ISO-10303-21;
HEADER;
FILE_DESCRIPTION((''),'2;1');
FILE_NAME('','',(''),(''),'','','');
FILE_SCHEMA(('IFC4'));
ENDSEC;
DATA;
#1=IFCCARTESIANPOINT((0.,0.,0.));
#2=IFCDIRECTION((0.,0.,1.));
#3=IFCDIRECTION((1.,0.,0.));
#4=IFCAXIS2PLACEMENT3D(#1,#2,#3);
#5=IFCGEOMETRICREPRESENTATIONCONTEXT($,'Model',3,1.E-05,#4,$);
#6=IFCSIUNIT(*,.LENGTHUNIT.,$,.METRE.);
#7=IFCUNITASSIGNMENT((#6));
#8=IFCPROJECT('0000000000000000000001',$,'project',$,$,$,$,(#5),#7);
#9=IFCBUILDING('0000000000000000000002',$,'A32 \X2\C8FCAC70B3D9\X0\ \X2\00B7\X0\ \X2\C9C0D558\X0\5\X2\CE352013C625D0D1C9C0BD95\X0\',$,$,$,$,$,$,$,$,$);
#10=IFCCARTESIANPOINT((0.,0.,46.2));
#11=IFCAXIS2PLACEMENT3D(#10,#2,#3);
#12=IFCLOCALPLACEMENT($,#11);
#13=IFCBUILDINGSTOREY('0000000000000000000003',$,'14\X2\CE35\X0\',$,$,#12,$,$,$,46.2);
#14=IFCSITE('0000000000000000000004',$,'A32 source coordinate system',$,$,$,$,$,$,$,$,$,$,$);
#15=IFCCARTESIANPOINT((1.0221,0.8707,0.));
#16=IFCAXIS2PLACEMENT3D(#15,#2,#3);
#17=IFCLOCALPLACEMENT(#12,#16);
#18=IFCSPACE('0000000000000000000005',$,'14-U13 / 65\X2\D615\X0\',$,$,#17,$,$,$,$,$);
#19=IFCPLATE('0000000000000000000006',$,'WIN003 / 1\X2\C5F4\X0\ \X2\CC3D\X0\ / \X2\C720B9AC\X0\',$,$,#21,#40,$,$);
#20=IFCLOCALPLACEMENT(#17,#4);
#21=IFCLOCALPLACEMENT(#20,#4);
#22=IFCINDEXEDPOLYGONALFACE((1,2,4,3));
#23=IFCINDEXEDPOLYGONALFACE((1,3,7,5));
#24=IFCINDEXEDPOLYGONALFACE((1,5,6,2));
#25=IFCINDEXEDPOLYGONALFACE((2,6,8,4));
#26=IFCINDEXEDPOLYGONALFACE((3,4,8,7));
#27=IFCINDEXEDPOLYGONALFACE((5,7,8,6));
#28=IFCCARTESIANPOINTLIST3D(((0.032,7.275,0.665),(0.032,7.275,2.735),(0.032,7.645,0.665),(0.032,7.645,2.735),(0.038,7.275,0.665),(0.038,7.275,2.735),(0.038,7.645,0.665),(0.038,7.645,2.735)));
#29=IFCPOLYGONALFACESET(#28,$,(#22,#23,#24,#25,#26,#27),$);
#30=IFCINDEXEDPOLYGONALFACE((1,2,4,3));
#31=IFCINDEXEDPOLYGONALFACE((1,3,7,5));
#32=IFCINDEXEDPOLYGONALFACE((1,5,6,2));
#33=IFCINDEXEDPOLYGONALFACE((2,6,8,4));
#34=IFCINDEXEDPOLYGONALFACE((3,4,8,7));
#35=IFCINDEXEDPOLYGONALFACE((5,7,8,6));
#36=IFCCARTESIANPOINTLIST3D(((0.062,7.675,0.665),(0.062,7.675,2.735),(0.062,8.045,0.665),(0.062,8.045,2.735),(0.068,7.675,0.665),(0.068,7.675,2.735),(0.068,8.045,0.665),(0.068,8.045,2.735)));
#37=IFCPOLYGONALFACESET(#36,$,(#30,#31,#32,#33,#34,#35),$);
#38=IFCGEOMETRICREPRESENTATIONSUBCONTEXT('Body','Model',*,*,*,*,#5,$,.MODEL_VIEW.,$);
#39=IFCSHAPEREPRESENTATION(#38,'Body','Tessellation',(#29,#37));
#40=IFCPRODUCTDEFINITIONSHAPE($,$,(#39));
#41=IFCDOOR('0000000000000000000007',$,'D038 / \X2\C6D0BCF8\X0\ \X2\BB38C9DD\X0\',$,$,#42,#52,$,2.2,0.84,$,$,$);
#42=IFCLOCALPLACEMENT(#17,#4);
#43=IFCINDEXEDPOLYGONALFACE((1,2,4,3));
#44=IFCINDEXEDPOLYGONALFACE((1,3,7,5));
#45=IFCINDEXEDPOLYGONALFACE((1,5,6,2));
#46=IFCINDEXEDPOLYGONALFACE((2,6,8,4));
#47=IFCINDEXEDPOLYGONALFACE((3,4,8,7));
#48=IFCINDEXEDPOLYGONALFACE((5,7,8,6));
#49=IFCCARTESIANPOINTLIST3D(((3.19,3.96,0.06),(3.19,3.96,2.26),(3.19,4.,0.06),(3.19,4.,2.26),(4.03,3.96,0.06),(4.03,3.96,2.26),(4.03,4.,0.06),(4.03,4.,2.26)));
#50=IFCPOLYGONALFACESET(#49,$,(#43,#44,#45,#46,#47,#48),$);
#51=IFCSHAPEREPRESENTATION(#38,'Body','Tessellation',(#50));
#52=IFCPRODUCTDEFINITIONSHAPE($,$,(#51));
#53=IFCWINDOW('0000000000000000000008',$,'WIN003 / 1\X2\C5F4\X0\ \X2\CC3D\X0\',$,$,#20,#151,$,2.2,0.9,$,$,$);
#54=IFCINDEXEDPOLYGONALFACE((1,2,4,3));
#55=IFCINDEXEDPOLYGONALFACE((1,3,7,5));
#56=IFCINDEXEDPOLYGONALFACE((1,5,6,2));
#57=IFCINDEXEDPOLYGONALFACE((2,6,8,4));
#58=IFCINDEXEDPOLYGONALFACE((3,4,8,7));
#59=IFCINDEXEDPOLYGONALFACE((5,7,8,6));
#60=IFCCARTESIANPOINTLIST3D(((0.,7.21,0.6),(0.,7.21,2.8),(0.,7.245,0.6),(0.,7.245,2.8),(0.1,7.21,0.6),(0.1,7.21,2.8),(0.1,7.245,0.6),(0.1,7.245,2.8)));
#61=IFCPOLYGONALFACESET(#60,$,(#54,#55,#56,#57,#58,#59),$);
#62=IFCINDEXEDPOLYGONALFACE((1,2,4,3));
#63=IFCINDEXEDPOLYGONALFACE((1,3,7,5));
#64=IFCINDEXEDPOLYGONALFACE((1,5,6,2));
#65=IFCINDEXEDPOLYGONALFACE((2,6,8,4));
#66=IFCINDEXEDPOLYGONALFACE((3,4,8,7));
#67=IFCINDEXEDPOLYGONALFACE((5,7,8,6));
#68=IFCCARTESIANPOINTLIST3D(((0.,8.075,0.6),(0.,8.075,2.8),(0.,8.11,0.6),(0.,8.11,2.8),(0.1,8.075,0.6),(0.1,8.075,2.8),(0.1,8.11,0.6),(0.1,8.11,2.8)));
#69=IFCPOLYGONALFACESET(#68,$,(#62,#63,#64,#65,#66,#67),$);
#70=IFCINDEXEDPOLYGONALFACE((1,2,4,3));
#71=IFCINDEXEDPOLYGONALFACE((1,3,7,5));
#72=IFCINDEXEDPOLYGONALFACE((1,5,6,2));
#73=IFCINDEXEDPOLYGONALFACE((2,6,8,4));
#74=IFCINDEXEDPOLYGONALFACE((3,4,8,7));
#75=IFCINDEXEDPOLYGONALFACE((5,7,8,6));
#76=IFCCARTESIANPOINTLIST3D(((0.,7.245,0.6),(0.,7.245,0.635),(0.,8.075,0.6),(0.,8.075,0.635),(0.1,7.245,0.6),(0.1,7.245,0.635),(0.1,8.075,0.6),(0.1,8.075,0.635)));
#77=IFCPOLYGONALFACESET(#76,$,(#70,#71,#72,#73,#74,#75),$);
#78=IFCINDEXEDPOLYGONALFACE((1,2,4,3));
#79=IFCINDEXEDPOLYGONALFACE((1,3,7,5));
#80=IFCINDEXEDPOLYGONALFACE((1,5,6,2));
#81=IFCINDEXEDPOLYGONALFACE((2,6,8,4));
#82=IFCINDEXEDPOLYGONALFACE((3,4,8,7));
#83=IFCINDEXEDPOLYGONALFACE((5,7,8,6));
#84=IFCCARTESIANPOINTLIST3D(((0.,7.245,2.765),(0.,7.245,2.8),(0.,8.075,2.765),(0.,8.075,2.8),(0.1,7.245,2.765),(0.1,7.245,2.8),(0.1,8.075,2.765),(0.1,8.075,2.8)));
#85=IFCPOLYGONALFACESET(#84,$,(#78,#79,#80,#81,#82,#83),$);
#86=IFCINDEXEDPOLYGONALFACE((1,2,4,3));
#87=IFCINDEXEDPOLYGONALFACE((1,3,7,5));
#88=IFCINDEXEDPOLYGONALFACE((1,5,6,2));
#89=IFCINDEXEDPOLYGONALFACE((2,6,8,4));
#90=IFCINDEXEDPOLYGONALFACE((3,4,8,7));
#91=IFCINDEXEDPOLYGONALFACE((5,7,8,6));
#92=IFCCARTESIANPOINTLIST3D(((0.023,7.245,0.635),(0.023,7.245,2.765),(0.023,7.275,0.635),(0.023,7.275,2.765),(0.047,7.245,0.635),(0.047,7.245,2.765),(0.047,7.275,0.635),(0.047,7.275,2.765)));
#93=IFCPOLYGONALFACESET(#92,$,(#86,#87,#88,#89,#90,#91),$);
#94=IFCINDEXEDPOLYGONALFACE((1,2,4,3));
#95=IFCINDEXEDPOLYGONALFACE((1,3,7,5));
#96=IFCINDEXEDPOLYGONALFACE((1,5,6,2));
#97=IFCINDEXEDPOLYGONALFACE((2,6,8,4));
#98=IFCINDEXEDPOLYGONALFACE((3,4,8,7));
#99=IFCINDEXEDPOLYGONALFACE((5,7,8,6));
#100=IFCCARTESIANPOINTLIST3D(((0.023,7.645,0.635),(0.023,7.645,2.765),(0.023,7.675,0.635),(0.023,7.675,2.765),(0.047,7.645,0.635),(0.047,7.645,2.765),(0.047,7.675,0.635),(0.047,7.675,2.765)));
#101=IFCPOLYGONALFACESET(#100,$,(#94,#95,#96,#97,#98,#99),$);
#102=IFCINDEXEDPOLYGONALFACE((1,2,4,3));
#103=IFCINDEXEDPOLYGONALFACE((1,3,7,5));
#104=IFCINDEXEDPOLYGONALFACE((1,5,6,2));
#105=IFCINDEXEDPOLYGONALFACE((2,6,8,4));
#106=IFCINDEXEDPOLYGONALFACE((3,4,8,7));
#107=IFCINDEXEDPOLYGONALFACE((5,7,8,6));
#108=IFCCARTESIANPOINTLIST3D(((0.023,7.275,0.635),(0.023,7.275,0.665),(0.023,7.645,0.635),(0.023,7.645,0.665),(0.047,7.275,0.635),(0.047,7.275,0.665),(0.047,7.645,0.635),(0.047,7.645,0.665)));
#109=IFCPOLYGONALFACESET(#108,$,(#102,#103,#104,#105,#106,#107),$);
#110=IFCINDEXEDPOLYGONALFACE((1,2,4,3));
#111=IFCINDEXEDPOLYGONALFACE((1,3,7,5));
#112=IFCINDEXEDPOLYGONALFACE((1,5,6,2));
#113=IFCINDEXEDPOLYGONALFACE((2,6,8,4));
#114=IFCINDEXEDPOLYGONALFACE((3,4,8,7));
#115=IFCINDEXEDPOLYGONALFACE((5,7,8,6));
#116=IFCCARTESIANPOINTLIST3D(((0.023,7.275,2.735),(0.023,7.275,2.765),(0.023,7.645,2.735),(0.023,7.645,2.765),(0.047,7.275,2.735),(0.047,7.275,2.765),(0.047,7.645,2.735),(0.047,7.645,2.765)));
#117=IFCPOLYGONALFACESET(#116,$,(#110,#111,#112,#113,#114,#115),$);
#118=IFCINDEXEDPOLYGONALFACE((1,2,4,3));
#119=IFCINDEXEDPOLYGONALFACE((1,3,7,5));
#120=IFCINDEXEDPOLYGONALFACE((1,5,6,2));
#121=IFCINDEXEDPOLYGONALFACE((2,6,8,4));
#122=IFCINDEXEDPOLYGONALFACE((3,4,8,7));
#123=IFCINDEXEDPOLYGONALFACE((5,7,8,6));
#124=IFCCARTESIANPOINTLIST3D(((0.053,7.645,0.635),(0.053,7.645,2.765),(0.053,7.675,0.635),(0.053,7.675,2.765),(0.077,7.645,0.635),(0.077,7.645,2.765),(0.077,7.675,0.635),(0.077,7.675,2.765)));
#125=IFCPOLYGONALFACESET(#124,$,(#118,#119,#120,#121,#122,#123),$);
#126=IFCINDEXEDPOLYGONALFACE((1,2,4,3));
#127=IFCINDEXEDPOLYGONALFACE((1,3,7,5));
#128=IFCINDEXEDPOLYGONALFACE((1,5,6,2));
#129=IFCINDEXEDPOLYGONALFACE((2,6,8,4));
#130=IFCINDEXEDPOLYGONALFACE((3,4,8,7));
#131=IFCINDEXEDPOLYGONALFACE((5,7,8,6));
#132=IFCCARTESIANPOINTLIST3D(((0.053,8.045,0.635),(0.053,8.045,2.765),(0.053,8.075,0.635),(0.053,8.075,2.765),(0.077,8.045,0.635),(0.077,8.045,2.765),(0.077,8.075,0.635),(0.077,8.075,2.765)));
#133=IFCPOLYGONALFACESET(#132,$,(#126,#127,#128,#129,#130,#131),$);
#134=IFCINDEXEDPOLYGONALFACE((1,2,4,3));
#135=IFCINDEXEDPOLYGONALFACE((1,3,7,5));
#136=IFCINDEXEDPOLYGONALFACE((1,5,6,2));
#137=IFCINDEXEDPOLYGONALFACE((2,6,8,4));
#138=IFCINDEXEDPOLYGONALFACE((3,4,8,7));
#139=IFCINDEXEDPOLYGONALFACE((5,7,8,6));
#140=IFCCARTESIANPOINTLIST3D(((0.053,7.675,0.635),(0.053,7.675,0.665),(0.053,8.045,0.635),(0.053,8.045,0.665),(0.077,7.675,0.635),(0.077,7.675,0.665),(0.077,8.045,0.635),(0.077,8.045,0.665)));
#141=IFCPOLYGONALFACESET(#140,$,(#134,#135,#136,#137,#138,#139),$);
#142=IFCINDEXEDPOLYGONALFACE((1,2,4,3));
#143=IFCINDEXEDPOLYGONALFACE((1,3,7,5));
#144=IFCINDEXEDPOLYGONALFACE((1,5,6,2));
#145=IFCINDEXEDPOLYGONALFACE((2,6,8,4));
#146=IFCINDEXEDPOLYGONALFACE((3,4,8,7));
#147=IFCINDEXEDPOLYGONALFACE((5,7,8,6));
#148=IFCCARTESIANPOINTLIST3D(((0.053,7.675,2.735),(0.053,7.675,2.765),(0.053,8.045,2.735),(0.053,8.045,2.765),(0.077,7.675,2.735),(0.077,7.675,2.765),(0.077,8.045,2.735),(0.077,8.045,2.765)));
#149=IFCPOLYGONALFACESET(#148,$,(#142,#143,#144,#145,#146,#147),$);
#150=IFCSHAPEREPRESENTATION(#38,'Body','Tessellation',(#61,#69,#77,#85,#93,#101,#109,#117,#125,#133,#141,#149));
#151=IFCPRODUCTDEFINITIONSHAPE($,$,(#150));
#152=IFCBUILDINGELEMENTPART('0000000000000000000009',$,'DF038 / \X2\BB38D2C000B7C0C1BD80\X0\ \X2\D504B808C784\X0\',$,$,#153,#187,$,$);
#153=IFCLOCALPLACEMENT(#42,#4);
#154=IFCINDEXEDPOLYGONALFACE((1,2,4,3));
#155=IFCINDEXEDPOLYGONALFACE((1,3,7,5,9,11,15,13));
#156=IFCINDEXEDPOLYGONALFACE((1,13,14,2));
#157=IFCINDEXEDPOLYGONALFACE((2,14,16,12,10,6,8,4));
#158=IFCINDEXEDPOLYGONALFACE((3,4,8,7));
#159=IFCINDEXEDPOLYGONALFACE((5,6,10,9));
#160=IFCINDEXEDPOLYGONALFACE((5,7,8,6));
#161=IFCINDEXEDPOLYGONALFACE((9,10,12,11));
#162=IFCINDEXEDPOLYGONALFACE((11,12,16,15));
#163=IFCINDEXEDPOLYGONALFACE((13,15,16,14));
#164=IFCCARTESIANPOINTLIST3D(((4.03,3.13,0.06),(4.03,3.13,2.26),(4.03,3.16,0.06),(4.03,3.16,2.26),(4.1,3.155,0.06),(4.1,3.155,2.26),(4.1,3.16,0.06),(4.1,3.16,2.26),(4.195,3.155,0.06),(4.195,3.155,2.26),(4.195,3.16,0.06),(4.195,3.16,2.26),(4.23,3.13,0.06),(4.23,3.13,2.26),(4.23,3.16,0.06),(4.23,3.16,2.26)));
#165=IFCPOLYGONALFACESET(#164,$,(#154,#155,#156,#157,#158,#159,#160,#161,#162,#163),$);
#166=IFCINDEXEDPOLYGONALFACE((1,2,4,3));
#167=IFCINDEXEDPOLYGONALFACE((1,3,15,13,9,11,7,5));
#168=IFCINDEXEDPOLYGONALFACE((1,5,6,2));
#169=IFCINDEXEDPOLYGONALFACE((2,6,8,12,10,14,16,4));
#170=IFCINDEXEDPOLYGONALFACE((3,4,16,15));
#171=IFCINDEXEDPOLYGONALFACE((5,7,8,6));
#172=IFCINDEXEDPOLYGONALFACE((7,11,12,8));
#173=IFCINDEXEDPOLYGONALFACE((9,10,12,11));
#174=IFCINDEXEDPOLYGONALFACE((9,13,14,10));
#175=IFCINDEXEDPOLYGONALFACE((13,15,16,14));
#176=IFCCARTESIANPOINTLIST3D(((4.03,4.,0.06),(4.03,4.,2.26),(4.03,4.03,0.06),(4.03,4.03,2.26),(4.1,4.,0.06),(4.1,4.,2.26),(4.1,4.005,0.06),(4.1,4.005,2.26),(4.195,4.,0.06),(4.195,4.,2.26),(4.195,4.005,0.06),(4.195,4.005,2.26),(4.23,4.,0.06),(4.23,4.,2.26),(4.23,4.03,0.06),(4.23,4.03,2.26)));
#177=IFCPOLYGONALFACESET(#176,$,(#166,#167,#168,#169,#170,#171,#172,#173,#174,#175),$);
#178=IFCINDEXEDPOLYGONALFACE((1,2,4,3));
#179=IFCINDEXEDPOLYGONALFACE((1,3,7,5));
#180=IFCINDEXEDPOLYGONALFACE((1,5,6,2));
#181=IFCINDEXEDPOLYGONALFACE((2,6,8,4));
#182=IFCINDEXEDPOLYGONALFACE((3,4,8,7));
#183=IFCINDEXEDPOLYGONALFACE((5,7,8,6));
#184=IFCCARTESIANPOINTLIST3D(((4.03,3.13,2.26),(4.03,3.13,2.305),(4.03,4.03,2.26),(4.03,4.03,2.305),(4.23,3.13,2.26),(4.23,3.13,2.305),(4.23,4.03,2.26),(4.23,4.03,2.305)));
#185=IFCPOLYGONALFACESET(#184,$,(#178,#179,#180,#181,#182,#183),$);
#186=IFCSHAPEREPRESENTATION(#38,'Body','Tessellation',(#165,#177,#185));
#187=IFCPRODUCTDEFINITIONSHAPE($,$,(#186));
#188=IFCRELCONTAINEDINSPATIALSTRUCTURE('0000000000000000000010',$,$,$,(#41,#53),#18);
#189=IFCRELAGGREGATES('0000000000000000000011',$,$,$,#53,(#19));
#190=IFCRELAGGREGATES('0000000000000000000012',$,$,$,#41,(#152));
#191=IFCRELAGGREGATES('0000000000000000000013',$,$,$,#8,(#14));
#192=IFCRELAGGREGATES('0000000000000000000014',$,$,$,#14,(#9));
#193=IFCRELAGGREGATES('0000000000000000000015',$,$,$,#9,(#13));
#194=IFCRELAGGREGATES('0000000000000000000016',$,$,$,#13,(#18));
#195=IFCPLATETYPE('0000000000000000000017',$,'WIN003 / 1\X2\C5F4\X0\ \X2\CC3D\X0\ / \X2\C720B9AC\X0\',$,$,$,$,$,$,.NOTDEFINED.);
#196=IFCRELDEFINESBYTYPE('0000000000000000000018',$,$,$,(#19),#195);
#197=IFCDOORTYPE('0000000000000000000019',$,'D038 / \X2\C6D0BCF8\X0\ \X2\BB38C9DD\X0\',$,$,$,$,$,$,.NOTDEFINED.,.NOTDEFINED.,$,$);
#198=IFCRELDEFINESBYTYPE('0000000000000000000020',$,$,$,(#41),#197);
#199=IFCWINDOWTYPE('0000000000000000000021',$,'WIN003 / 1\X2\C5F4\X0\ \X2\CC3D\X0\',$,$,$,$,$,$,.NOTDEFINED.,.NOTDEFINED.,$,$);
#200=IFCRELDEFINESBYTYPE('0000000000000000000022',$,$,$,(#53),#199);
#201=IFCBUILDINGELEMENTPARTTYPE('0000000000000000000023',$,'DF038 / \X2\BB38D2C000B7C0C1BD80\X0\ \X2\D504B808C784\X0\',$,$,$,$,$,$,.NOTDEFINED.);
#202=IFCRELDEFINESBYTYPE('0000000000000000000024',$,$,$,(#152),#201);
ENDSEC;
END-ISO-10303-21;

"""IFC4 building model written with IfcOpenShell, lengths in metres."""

from ifc_helpers import new_model, si_unit, frame, origin, origin_with_axes, place, context, subcontext, project, spatial, polyline, outline, extrude, source, transform, mapped, type_object, type_shapes, element, aggregate, save


model = new_model("IFC4")

# Units and contexts
model_context = context("Model", 3, precision=1e-05, world=origin_with_axes())
body_context = subcontext(model_context, "Body", "Model", "MODEL_VIEW")
ifc_project = project(units=[si_unit("LENGTHUNIT", "METRE")], contexts=[model_context])

# Plate
storey_placement = place(None, frame((0.0, 0.0, 46.2), z_axis=(0.0, 0.0, 1.0), x_axis=(1.0, 0.0, 0.0)))
space_placement = place(storey_placement, frame((1.0221, 0.8707, 0.0), z_axis=(0.0, 0.0, 1.0), x_axis=(1.0, 0.0, 0.0)))
plate_type_1 = type_object("IfcPlateType", Name="WIN003 / 1열 창 / 유리", PredefinedType="NOTDEFINED")
shared_shape_1 = source(origin(), body_context, "Body", "SweptSolid", [
    extrude(outline(polyline([(0.032, 7.275), (0.032, 7.645), (0.038, 7.645), (0.038, 7.275), (0.032, 7.275)])), frame((0.0, 0.0, 0.665)), (0.0, 0.0, 1.0), 2.07),
    extrude(outline(polyline([(0.062, 7.675), (0.062, 8.045), (0.068, 8.045), (0.068, 7.675), (0.062, 7.675)])), frame((0.0, 0.0, 0.665)), (0.0, 0.0, 1.0), 2.07),
])
type_shapes(plate_type_1, [shared_shape_1])
window_1_placement = place(space_placement, origin_with_axes())
plate_1_placement = place(window_1_placement, origin_with_axes())
plate_1 = element("IfcPlate", 1, at=plate_1_placement, type_object=plate_type_1, Name="WIN003 / 1열 창 / 유리", context=body_context, shape_type="MappedRepresentation", body=[
    mapped(shared_shape_1, transform((0.0, 0.0, 0.0), scale=1.0)),
])

# Site, building, storey, space
site = spatial("IfcSite", under=ifc_project, Name="A32 source coordinate system")
building = spatial("IfcBuilding", under=site, Name="A32 주거동 · 지하5층–옥탑지붕")
storey = spatial("IfcBuildingStorey", under=building, at=storey_placement, Name="14층", Elevation=46.2)
space = spatial("IfcSpace", under=storey, at=space_placement, Name="14-U13 / 65형")

# Door
door_type_1 = type_object("IfcDoorType", Name="D038 / 원본 문짝", OperationType="NOTDEFINED", PredefinedType="NOTDEFINED")
shared_shape_2 = source(origin(), body_context, "Body", "SweptSolid", [
    extrude(outline(polyline([(3.19, 3.96), (3.19, 4.0), (4.03, 4.0), (4.03, 3.96), (3.19, 3.96)])), frame((0.0, 0.0, 0.06)), (0.0, 0.0, 1.0), 2.2),
])
type_shapes(door_type_1, [shared_shape_2])
door_1_placement = place(space_placement, origin_with_axes())
door_1 = element("IfcDoor", 2, at=door_1_placement, inside=space, type_object=door_type_1, Name="D038 / 원본 문짝", OverallHeight=2.2, OverallWidth=0.84, context=body_context, shape_type="MappedRepresentation", body=[
    mapped(shared_shape_2, transform((0.0, 0.0, 0.0), scale=1.0)),
])

# Window
window_type_1 = type_object("IfcWindowType", Name="WIN003 / 1열 창", PartitioningType="NOTDEFINED", PredefinedType="NOTDEFINED")
shared_shape_3 = source(origin(), body_context, "Body", "SweptSolid", [
    extrude(outline(polyline([(0.0, 7.21), (0.0, 7.245), (0.1, 7.245), (0.1, 7.21), (0.0, 7.21)])), frame((0.0, 0.0, 0.6)), (0.0, 0.0, 1.0), 2.2),
    extrude(outline(polyline([(0.0, 8.075), (0.0, 8.11), (0.1, 8.11), (0.1, 8.075), (0.0, 8.075)])), frame((0.0, 0.0, 0.6)), (0.0, 0.0, 1.0), 2.2),
    extrude(outline(polyline([(0.0, 7.245), (0.0, 8.075), (0.1, 8.075), (0.1, 7.245), (0.0, 7.245)])), frame((0.0, 0.0, 0.6)), (0.0, 0.0, 1.0), 0.035),
    extrude(outline(polyline([(0.0, 7.245), (0.0, 8.075), (0.1, 8.075), (0.1, 7.245), (0.0, 7.245)])), frame((0.0, 0.0, 2.765)), (0.0, 0.0, 1.0), 0.035),
    extrude(outline(polyline([(0.023, 7.245), (0.023, 7.275), (0.047, 7.275), (0.047, 7.245), (0.023, 7.245)])), frame((0.0, 0.0, 0.635)), (0.0, 0.0, 1.0), 2.13),
    extrude(outline(polyline([(0.023, 7.645), (0.023, 7.675), (0.047, 7.675), (0.047, 7.645), (0.023, 7.645)])), frame((0.0, 0.0, 0.635)), (0.0, 0.0, 1.0), 2.13),
    extrude(outline(polyline([(0.023, 7.275), (0.023, 7.645), (0.047, 7.645), (0.047, 7.275), (0.023, 7.275)])), frame((0.0, 0.0, 0.635)), (0.0, 0.0, 1.0), 0.03),
    extrude(outline(polyline([(0.023, 7.275), (0.023, 7.645), (0.047, 7.645), (0.047, 7.275), (0.023, 7.275)])), frame((0.0, 0.0, 2.735)), (0.0, 0.0, 1.0), 0.03),
    extrude(outline(polyline([(0.053, 7.645), (0.053, 7.675), (0.077, 7.675), (0.077, 7.645), (0.053, 7.645)])), frame((0.0, 0.0, 0.635)), (0.0, 0.0, 1.0), 2.13),
    extrude(outline(polyline([(0.053, 8.045), (0.053, 8.075), (0.077, 8.075), (0.077, 8.045), (0.053, 8.045)])), frame((0.0, 0.0, 0.635)), (0.0, 0.0, 1.0), 2.13),
    extrude(outline(polyline([(0.053, 7.675), (0.053, 8.045), (0.077, 8.045), (0.077, 7.675), (0.053, 7.675)])), frame((0.0, 0.0, 0.635)), (0.0, 0.0, 1.0), 0.03),
    extrude(outline(polyline([(0.053, 7.675), (0.053, 8.045), (0.077, 8.045), (0.077, 7.675), (0.053, 7.675)])), frame((0.0, 0.0, 2.735)), (0.0, 0.0, 1.0), 0.03),
])
type_shapes(window_type_1, [shared_shape_3])
window_1 = element("IfcWindow", 3, at=window_1_placement, inside=space, type_object=window_type_1, Name="WIN003 / 1열 창", OverallHeight=2.2, OverallWidth=0.9, context=body_context, shape_type="MappedRepresentation", body=[
    mapped(shared_shape_3, transform((0.0, 0.0, 0.0), scale=1.0)),
])
aggregate(window_1, [plate_1])

# Building element part
building_element_part_type_1 = type_object("IfcBuildingElementPartType", Name="DF038 / 문틀·상부 프레임", PredefinedType="NOTDEFINED")
shared_shape_4 = source(origin(), body_context, "Body", "SweptSolid", [
    extrude(outline(polyline([(4.03, 3.16), (4.1, 3.16), (4.1, 3.155), (4.195, 3.155), (4.195, 3.16), (4.23, 3.16), (4.23, 3.13), (4.03, 3.13), (4.03, 3.16)])), frame((0.0, 0.0, 0.06)), (0.0, 0.0, 1.0), 2.2),
    extrude(outline(polyline([(4.23, 4.03), (4.23, 4.0), (4.195, 4.0), (4.195, 4.005), (4.1, 4.005), (4.1, 4.0), (4.03, 4.0), (4.03, 4.03), (4.23, 4.03)])), frame((0.0, 0.0, 0.06)), (0.0, 0.0, 1.0), 2.2),
    extrude(outline(polyline([(4.03, 3.13), (4.03, 4.03), (4.23, 4.03), (4.23, 3.13), (4.03, 3.13)])), frame((0.0, 0.0, 2.26)), (0.0, 0.0, 1.0), 0.045),
])
type_shapes(building_element_part_type_1, [shared_shape_4])
building_element_part_1_placement = place(door_1_placement, origin_with_axes())
building_element_part_1 = element("IfcBuildingElementPart", 4, at=building_element_part_1_placement, type_object=building_element_part_type_1, Name="DF038 / 문틀·상부 프레임", context=body_context, shape_type="MappedRepresentation", body=[
    mapped(shared_shape_4, transform((0.0, 0.0, 0.0), scale=1.0)),
])
aggregate(door_1, [building_element_part_1])

save(model, "model.ifc")
